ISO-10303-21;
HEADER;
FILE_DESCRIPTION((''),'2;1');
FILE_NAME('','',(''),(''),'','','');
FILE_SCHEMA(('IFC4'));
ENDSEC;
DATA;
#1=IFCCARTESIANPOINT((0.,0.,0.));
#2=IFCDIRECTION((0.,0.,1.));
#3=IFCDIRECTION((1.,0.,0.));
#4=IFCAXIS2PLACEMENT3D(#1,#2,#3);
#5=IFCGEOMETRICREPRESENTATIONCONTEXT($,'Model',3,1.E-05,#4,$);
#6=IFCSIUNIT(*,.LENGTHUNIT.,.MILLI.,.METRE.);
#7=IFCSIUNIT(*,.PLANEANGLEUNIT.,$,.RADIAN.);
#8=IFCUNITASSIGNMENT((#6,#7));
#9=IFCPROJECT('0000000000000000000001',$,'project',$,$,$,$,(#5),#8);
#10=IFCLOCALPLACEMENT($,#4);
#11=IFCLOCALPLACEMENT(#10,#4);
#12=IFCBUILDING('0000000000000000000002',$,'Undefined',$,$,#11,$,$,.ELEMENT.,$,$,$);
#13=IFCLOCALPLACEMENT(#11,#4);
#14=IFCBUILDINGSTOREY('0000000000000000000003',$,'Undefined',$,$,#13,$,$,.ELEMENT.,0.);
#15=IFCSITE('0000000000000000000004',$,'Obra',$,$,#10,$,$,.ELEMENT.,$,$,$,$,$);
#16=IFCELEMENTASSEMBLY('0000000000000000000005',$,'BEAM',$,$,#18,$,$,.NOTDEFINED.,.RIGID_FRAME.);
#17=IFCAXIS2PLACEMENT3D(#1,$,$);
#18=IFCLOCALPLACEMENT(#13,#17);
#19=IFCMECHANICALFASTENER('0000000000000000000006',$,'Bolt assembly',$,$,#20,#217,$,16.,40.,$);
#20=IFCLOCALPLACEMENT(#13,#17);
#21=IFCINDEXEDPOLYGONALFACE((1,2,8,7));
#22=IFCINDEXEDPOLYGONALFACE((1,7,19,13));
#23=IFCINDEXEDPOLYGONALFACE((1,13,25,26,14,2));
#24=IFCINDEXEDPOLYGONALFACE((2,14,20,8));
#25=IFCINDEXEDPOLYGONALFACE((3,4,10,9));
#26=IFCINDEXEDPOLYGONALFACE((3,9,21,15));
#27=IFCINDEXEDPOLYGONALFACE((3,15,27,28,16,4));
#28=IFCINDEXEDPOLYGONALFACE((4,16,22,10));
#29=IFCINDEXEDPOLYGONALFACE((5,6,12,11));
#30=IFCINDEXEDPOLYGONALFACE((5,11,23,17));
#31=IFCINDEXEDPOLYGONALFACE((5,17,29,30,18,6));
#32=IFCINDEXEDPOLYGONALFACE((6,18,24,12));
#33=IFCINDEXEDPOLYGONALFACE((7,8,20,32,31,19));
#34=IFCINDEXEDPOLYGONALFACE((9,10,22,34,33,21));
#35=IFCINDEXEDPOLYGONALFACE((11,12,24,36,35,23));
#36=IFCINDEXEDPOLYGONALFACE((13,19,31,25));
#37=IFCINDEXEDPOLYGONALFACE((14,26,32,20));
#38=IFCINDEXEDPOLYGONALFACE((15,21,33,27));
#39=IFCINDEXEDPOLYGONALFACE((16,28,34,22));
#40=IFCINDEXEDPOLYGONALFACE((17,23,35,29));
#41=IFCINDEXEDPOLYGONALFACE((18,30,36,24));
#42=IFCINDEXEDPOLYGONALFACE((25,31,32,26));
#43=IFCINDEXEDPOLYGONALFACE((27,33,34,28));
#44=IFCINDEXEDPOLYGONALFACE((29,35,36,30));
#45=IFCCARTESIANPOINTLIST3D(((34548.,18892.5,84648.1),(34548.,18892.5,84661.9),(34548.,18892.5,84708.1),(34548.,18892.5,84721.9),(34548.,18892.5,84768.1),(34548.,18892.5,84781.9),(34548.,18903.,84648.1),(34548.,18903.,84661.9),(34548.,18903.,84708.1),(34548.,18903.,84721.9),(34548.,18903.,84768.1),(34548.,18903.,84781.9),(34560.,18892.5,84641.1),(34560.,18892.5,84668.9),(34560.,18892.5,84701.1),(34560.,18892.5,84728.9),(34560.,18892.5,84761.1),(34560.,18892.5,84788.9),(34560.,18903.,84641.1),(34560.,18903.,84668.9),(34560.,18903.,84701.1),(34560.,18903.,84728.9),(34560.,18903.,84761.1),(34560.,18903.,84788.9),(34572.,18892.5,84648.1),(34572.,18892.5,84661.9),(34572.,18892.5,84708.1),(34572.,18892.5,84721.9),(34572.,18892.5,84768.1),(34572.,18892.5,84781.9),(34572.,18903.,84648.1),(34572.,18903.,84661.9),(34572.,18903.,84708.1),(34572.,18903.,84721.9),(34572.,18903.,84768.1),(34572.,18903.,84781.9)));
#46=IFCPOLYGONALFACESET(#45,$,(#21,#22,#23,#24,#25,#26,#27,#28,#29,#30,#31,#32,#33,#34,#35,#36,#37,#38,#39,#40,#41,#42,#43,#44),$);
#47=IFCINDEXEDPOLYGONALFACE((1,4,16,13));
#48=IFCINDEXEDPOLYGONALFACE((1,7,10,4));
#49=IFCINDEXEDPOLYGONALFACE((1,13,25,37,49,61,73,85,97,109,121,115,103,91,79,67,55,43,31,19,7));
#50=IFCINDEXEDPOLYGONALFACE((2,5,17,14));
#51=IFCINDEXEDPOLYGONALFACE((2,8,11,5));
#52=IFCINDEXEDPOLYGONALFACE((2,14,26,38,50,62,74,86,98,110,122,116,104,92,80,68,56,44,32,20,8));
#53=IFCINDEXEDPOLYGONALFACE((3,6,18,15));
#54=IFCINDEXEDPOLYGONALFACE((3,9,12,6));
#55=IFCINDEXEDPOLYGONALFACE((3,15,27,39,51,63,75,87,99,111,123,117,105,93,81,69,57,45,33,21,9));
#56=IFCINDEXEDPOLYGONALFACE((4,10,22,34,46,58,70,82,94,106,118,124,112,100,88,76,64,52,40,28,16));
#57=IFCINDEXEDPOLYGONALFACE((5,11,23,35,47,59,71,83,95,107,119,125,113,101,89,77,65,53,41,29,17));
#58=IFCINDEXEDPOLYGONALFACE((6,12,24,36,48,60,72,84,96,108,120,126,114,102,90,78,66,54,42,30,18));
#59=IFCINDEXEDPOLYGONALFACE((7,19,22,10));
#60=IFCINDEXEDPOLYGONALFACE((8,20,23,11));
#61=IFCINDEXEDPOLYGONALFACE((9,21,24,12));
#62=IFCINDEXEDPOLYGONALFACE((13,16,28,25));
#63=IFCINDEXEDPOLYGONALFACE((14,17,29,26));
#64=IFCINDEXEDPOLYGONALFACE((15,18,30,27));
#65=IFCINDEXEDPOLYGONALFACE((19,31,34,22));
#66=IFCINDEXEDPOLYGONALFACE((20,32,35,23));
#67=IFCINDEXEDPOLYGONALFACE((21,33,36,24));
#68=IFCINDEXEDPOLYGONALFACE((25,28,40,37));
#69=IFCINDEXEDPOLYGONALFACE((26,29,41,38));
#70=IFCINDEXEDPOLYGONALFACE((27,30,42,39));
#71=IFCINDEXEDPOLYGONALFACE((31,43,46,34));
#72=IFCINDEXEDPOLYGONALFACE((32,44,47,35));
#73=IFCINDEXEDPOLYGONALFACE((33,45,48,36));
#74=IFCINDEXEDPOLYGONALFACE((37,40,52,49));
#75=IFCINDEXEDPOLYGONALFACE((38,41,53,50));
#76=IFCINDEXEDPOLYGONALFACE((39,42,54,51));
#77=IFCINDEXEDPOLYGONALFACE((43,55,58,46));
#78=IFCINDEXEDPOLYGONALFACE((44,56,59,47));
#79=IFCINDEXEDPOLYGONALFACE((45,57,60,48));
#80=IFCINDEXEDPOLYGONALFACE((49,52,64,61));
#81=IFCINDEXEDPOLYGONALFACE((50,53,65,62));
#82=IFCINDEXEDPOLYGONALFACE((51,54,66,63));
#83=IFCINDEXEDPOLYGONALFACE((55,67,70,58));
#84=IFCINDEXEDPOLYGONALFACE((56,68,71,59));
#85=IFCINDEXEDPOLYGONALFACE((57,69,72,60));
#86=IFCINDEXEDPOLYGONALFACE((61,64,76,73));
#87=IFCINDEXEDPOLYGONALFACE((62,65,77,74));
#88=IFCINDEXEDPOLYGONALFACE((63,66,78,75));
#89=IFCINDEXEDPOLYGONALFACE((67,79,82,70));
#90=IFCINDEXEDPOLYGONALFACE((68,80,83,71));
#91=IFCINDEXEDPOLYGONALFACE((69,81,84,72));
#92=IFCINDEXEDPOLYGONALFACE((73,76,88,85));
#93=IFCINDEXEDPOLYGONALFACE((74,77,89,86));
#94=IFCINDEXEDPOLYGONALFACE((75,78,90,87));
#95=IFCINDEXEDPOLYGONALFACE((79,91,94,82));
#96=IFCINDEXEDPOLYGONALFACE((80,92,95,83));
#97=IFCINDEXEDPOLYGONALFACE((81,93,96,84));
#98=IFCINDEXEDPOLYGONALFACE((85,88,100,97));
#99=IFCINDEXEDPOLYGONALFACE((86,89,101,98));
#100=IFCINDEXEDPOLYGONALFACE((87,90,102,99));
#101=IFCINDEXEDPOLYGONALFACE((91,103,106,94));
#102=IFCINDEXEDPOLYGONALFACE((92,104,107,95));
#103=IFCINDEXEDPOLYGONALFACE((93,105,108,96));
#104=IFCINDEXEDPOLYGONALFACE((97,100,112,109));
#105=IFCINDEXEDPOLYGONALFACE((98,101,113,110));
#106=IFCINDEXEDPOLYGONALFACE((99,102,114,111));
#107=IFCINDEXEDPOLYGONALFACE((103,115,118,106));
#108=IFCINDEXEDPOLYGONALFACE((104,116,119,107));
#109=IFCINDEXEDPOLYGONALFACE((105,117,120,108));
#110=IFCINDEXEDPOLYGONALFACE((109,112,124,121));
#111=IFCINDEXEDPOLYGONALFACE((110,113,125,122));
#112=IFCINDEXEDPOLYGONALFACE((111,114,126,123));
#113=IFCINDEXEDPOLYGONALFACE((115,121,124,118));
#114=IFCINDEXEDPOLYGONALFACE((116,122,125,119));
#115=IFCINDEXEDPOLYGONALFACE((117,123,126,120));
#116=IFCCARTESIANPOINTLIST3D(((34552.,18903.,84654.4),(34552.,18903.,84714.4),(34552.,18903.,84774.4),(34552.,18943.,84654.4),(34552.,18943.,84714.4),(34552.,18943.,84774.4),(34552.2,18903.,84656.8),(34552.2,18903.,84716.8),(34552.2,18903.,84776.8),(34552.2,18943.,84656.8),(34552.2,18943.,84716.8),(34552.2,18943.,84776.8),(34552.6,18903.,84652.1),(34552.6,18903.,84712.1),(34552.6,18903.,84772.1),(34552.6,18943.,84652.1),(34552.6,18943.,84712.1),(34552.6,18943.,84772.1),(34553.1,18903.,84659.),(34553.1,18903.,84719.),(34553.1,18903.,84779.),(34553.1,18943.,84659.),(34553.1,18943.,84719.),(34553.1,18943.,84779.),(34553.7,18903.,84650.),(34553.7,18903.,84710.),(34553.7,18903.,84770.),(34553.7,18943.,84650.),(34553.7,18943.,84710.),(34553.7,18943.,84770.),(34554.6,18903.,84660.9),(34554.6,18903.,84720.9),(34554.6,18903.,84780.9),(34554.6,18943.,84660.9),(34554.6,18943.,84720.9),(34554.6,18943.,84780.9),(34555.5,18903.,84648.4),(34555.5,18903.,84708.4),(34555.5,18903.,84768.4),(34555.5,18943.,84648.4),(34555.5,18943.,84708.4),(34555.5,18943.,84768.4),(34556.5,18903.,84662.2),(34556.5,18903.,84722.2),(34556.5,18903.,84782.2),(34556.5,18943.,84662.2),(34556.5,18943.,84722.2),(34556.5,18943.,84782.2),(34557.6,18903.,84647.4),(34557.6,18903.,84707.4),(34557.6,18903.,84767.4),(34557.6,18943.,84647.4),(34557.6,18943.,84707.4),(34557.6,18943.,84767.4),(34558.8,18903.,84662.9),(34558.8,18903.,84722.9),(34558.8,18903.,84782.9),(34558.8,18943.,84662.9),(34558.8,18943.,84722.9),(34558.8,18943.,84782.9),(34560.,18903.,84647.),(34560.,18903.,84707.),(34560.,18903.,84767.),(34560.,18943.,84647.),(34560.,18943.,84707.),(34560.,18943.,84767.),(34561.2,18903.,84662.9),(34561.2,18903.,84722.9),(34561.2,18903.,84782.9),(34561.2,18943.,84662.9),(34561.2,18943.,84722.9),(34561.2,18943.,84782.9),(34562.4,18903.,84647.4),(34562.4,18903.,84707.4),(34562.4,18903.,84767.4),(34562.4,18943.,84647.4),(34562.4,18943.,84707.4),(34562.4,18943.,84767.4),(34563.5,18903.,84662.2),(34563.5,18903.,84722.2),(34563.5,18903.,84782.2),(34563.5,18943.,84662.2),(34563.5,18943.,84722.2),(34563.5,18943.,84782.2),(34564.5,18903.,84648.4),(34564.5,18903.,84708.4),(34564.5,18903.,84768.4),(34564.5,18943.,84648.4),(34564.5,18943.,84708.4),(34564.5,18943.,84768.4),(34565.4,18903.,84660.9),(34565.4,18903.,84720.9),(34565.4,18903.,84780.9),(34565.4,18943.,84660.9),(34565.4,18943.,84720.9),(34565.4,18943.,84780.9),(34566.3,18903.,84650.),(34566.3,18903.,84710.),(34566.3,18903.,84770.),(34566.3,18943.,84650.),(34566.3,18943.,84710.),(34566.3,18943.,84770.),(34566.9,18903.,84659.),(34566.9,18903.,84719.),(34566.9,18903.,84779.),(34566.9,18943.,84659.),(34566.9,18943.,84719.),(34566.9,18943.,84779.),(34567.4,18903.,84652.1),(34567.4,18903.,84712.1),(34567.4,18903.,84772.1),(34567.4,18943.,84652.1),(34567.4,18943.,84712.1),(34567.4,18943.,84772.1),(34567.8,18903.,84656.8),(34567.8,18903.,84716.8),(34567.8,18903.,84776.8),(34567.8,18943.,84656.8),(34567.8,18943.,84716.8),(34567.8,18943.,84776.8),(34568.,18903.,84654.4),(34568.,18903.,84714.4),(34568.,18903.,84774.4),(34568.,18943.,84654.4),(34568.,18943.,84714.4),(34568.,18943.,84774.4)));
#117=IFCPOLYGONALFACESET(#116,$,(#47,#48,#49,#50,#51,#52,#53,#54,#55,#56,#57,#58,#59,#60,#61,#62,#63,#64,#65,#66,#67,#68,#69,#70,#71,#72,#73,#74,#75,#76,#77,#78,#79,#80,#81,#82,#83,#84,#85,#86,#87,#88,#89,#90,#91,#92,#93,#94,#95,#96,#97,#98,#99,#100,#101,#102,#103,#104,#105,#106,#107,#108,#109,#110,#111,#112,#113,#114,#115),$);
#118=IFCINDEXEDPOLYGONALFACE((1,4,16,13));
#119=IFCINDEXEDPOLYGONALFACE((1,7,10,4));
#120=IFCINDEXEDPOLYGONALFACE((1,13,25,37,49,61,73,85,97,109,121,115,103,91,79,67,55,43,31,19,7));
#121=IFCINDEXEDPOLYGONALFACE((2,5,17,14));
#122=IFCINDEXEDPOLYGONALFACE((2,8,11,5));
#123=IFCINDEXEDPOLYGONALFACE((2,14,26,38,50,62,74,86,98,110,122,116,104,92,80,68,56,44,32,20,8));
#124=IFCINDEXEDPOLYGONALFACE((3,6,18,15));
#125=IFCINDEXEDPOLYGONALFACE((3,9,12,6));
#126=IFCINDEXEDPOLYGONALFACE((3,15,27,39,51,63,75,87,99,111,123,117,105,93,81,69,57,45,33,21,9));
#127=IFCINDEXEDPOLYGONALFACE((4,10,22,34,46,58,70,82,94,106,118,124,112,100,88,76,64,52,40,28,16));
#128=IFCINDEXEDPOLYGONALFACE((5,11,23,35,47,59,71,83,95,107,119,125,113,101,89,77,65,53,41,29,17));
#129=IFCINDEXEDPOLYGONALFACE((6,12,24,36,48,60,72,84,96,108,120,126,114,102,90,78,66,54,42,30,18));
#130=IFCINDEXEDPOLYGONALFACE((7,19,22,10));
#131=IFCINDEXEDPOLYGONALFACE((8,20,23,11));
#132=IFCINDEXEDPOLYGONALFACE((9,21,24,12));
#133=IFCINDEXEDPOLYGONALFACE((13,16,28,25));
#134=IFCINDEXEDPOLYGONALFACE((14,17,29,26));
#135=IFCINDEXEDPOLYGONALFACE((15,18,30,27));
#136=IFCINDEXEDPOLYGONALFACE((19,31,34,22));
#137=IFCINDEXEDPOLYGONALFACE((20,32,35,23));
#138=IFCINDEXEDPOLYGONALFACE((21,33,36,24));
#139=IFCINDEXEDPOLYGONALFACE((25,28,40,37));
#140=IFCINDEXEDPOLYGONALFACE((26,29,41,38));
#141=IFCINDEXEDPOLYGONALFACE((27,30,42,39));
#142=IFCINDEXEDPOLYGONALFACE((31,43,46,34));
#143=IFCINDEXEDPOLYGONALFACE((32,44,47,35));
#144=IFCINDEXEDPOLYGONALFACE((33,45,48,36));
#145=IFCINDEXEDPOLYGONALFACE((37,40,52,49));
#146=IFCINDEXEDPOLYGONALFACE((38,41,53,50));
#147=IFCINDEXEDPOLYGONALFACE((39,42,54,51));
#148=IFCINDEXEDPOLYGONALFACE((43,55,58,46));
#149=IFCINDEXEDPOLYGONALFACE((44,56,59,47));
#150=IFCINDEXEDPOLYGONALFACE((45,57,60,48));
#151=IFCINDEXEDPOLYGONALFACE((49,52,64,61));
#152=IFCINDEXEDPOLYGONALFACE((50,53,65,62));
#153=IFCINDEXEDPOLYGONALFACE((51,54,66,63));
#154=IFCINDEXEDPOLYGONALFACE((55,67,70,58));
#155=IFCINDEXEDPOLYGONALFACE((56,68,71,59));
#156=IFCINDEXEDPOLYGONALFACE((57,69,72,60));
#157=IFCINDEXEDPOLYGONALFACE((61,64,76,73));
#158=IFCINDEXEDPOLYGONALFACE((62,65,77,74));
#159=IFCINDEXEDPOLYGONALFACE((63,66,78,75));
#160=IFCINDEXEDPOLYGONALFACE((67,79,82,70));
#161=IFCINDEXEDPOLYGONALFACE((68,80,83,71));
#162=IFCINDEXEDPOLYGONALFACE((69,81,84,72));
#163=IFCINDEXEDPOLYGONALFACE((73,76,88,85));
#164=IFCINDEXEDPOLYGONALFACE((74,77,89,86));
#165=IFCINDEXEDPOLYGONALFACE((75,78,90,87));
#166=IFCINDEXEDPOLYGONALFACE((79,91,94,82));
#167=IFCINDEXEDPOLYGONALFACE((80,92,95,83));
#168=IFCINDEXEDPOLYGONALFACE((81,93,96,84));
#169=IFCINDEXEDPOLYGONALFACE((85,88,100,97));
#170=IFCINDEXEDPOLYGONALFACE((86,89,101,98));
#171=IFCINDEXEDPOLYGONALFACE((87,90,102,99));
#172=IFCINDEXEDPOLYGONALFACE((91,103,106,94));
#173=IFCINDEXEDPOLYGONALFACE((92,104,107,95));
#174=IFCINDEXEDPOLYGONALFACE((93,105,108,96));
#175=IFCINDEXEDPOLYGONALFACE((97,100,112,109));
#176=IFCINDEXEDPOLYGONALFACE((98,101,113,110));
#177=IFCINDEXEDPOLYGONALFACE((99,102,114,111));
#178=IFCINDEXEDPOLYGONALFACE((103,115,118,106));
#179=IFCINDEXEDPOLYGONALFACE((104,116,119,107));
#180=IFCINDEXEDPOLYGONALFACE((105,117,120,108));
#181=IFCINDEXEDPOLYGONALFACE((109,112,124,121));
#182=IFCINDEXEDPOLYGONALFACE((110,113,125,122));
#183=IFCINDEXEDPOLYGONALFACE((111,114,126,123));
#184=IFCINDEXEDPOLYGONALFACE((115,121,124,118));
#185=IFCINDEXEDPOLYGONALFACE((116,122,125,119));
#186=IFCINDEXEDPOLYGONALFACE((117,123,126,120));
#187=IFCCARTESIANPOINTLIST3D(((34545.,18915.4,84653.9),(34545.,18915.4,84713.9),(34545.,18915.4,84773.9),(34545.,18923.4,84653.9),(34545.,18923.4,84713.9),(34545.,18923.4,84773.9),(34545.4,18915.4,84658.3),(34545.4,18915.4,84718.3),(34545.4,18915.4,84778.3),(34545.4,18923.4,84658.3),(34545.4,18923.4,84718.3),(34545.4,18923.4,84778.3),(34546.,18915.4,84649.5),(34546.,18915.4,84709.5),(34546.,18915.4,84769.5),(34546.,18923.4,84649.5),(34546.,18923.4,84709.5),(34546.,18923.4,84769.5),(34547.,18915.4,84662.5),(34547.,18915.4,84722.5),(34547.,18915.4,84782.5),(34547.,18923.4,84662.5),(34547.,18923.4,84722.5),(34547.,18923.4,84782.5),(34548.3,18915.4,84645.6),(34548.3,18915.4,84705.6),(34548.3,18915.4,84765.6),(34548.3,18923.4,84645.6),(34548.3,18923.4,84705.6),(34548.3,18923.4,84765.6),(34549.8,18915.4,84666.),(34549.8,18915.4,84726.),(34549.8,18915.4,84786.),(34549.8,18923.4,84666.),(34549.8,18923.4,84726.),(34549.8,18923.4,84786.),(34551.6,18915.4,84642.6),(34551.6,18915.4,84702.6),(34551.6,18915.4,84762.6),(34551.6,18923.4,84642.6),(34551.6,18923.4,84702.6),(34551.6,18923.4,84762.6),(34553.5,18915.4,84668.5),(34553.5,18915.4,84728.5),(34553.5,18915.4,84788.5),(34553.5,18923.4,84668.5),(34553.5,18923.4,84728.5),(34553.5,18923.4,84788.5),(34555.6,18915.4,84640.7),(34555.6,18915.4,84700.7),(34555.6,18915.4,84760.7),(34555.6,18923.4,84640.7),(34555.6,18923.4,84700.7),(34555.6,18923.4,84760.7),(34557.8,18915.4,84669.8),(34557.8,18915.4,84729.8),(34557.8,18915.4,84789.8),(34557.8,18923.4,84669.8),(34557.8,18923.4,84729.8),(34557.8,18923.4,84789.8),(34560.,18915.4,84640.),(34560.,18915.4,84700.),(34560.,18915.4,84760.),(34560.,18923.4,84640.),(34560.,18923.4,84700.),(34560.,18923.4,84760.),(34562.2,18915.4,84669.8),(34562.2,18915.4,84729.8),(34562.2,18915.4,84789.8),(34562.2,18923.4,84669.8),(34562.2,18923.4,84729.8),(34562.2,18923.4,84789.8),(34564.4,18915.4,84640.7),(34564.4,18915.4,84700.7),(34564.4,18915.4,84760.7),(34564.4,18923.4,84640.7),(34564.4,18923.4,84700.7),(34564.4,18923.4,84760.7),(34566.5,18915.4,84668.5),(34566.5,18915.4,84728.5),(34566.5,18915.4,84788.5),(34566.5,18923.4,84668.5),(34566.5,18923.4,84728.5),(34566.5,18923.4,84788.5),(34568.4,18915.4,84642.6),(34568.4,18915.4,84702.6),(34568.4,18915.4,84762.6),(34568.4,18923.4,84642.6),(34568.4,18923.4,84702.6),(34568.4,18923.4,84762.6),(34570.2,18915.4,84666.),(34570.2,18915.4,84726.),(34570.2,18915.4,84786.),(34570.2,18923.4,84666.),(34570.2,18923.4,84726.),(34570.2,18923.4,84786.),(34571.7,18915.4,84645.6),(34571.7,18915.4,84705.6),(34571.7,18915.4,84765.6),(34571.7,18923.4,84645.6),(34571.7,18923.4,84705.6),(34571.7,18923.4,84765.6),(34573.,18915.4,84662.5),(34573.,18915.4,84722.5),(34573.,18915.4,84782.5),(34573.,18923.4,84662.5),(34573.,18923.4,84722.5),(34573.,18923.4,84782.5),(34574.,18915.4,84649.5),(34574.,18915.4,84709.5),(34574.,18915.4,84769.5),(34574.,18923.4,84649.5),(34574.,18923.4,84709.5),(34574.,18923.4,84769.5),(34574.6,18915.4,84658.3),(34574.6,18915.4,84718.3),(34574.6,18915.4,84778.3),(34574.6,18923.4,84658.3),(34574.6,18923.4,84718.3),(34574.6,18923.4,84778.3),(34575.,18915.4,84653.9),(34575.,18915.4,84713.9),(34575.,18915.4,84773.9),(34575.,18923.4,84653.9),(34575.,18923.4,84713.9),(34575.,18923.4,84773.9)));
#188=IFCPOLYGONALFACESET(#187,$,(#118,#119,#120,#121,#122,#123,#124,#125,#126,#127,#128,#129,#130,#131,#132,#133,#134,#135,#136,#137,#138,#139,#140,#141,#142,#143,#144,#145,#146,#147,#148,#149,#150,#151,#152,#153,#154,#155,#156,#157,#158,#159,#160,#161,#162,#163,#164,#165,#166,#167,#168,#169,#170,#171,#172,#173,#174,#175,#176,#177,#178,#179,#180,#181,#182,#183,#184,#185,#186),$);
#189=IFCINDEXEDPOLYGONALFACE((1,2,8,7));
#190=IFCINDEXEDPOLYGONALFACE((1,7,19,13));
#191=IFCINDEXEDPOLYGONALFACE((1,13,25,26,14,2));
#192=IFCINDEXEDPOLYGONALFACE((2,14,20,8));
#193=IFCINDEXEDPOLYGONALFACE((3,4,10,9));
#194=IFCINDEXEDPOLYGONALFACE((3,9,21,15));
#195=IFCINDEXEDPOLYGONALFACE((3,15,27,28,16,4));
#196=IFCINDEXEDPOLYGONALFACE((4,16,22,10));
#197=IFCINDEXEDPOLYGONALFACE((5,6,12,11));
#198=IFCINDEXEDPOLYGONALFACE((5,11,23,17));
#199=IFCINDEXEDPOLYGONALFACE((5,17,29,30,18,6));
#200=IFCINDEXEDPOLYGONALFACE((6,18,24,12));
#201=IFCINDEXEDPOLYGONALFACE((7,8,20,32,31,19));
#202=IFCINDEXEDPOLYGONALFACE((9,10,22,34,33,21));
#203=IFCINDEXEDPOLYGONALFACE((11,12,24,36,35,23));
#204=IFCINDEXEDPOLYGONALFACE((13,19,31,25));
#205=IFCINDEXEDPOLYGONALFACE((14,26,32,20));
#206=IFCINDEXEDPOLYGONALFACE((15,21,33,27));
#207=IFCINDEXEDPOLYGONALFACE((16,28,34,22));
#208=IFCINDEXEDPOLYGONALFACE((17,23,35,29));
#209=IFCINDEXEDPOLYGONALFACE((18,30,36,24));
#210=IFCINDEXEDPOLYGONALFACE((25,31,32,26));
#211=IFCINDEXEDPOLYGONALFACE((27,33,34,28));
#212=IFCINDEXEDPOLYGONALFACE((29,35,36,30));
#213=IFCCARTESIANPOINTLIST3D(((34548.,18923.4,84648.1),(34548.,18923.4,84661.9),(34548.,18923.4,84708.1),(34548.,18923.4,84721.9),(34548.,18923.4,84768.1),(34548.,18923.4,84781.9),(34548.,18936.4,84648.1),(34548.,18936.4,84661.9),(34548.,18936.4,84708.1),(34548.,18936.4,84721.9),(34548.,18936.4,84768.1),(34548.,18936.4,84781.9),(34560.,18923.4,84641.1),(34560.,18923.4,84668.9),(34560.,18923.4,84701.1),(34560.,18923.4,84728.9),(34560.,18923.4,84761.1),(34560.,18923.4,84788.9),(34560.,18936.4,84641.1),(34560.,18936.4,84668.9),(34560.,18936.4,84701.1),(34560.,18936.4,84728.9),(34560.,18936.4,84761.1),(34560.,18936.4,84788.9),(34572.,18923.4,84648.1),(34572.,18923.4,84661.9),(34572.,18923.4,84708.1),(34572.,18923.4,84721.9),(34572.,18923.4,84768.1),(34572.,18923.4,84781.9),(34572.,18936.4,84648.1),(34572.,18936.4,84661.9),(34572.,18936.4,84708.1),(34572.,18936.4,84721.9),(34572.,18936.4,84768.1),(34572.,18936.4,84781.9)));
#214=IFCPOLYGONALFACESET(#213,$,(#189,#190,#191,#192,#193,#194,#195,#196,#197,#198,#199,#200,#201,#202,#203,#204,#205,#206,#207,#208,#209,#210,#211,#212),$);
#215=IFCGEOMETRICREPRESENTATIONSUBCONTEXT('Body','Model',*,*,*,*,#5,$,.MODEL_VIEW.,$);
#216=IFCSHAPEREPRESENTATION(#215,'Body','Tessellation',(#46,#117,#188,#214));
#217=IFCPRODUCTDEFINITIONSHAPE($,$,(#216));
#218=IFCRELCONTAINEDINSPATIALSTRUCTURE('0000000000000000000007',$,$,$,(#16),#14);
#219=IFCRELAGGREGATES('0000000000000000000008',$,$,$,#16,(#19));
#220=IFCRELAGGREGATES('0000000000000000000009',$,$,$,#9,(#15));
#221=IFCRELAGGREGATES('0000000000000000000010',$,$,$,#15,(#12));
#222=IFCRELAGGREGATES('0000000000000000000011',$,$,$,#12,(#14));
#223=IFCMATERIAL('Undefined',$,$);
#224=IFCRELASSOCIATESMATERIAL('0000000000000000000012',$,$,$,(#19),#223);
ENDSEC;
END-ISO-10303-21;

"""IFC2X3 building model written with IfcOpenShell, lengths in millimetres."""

from ifc_helpers import new_model, si_unit, frame, origin_with_axes, origin_2d_with_axis, place, context, subcontext, project, spatial, polyline, circle, outline, extrude, source, transform, mapped, material, element, aggregate, save


model = new_model("IFC2X3")

# Units and contexts
model_context = context("Model", 3, precision=1e-05, world=origin_with_axes())
body_context = subcontext(model_context, "Body", "Model", "MODEL_VIEW")
ifc_project = project(units=[si_unit("LENGTHUNIT", "METRE", prefix="MILLI"), si_unit("PLANEANGLEUNIT", "RADIAN")], contexts=[model_context])

# Site, building, storey
site_placement = place(None, origin_with_axes())
site = spatial("IfcSite", under=ifc_project, at=site_placement, Name="Obra", CompositionType="ELEMENT")
building_placement = place(site_placement, origin_with_axes())
building = spatial("IfcBuilding", under=site, at=building_placement, Name="Undefined", CompositionType="ELEMENT")
storey_placement = place(building_placement, origin_with_axes())
storey = spatial("IfcBuildingStorey", under=building, at=storey_placement, Name="Undefined", CompositionType="ELEMENT", Elevation=0.0)

# Element assembly, mechanical fastener
ifc_material_1 = material(Name="Undefined")
shared_shape_1 = source(origin_with_axes(), body_context, "Body", "SweptSolid", [
    extrude(outline(polyline([(13.9, 0.0), (6.9, 12.0), (-6.9, 12.0), (-13.9, 0.0), (-6.9, -12.0), (6.9, -12.0), (13.9, 0.0)])), frame((0.0, -19.7, 0.0), z_axis=(0.0, 1.0, 0.0), x_axis=(1.0, 0.0, 0.0)), (0.0, 0.0, 1.0), 10.6),
    extrude(circle(Radius=8.0, at=origin_2d_with_axis()), frame((0.0, -9.1, 0.0), z_axis=(0.0, 1.0, 0.0), x_axis=(1.0, 0.0, 0.0)), (0.0, 0.0, 1.0), 40.0),
    extrude(circle(Radius=15.0, at=origin_2d_with_axis()), frame((0.0, 3.3, 0.0), z_axis=(0.0, 1.0, 0.0), x_axis=(1.0, 0.0, 0.0)), (0.0, 0.0, 1.0), 8.0),
    extrude(outline(polyline([(13.9, 0.0), (6.9, 12.0), (-6.9, 12.0), (-13.9, 0.0), (-6.9, -12.0), (6.9, -12.0), (13.9, 0.0)])), frame((0.0, 11.3, 0.0), z_axis=(0.0, 1.0, 0.0), x_axis=(1.0, 0.0, 0.0)), (0.0, 0.0, 1.0), 13.0),
])
assembly_1_placement = place(storey_placement, origin_with_axes())
assembly_1 = element("IfcElementAssembly", 1, at=assembly_1_placement, inside=storey, Name="BEAM", AssemblyPlace="NOTDEFINED", PredefinedType="RIGID_FRAME")
mechanical_fastener_1_placement = place(assembly_1_placement, frame((34510.0, 18912.1, 84835.0), z_axis=(1.0, 0.0, 0.0), x_axis=(0.0, 0.0, -1.0)))
mechanical_fastener_1 = element("IfcMechanicalFastener", 2, at=mechanical_fastener_1_placement, material=ifc_material_1, Name="Bolt assembly", NominalDiameter=16.0, NominalLength=40.0, context=body_context, shape_type="MappedRepresentation", body=[
    mapped(shared_shape_1, transform((60.0, 0.0, 50.0))),
    mapped(shared_shape_1, transform((120.0, 0.0, 50.0))),
    mapped(shared_shape_1, transform((180.0, 0.0, 50.0))),
])
aggregate(assembly_1, [mechanical_fastener_1])

save(model, "model.ifc")
